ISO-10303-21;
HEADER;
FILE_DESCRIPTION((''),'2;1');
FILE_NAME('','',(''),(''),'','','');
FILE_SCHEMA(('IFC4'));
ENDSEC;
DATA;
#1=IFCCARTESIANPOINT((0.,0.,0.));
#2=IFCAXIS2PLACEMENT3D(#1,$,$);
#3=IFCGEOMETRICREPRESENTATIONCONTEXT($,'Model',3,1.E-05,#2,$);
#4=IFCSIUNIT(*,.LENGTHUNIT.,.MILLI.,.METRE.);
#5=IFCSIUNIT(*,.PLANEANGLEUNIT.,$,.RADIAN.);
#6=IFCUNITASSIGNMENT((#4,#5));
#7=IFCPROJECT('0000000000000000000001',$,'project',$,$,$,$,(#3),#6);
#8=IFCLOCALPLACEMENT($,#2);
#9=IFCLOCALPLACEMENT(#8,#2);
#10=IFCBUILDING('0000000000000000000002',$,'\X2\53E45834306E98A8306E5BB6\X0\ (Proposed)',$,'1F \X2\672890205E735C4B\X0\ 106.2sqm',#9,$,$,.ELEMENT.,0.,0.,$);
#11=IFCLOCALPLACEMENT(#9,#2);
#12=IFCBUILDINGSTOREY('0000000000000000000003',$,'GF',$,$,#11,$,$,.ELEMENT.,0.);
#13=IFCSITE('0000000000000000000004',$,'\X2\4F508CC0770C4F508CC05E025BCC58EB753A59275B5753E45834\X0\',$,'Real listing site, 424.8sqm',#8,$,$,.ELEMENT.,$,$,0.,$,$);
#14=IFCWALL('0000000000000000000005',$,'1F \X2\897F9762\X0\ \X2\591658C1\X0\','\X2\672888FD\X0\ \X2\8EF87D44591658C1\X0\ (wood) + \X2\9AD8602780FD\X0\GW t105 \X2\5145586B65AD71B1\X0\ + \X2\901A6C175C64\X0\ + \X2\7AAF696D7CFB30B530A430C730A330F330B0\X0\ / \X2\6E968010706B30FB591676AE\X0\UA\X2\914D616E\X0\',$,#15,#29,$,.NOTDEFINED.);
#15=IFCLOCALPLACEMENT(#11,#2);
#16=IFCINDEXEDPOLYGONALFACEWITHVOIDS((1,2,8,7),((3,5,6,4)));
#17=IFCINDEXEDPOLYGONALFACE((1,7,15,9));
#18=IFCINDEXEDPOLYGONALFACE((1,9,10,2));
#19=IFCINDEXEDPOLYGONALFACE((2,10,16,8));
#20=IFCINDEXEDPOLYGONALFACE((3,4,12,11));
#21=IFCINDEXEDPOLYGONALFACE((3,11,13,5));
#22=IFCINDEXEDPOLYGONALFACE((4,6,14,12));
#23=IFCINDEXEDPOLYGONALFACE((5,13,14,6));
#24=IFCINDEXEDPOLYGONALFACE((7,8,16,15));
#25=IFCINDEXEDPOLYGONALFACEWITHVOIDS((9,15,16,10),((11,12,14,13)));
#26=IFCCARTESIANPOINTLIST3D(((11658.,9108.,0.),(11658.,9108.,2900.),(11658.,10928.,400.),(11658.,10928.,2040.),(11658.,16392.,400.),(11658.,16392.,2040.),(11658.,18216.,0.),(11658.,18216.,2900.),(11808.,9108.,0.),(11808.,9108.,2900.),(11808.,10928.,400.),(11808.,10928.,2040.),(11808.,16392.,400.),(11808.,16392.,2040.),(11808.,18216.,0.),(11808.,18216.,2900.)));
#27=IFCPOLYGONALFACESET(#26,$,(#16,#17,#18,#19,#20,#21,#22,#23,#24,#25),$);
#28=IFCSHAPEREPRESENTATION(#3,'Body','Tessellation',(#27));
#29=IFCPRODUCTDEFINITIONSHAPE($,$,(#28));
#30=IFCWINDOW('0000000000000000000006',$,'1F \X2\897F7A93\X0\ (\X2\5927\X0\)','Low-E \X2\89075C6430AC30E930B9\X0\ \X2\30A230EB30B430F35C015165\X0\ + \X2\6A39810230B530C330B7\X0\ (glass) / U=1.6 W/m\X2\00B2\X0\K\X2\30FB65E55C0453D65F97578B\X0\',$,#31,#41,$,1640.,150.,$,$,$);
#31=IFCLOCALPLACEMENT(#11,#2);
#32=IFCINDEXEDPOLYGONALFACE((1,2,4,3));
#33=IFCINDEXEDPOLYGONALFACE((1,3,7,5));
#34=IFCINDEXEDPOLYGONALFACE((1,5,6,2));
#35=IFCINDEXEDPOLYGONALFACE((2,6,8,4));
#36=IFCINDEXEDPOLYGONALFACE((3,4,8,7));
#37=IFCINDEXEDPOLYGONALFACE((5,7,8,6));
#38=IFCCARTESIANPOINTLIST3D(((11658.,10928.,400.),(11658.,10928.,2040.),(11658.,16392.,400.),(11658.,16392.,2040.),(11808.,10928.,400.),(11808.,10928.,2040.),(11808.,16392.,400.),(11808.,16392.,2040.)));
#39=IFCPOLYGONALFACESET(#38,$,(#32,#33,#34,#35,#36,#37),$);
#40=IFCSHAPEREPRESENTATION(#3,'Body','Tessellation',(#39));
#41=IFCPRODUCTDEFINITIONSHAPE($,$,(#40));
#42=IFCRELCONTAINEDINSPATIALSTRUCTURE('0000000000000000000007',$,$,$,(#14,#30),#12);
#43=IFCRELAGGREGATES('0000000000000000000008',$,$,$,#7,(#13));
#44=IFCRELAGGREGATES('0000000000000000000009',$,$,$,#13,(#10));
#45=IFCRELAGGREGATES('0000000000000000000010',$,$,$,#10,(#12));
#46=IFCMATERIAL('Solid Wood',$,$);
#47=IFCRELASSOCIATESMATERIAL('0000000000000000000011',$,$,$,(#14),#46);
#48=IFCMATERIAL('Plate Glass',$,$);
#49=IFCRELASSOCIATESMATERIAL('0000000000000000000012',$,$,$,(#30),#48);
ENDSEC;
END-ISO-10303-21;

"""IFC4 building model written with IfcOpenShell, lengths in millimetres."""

from ifc_helpers import new_model, si_unit, frame, frame_2d, origin, place, context, project, spatial, rectangle, extrude, material, element, fill, save


model = new_model("IFC4")

# Units and contexts
model_context = context("Model", 3, precision=1e-05, world=origin())
ifc_project = project(units=[si_unit("LENGTHUNIT", "METRE", prefix="MILLI"), si_unit("PLANEANGLEUNIT", "RADIAN")], contexts=[model_context])

# Site, building, storey
site_placement = place(None, origin())
site = spatial("IfcSite", under=ifc_project, at=site_placement, Name="佐賀県佐賀市富士町大字古場", ObjectType="Real listing site, 424.8sqm", CompositionType="ELEMENT", RefElevation=0.0)
building_placement = place(site_placement, origin())
building = spatial("IfcBuilding", under=site, at=building_placement, Name="古場の風の家 (Proposed)", ObjectType="1F 木造平屋 106.2sqm", CompositionType="ELEMENT", ElevationOfRefHeight=0.0, ElevationOfTerrain=0.0)
storey_placement = place(building_placement, origin())
storey = spatial("IfcBuildingStorey", under=building, at=storey_placement, Name="GF", CompositionType="ELEMENT", Elevation=0.0)

# Shared definitions
ifc_material_1 = material(Name="Solid Wood")

# Shared definitions
ifc_material_2 = material(Name="Plate Glass")

# Wall, opening, window
wall_1_placement = place(storey_placement, frame((5829.0, 4554.0, 0.0)))
wall_1 = element("IfcWall", 1, at=wall_1_placement, inside=storey, material=ifc_material_1, Name="1F 西面 外壁", Description="木製 軸組外壁 (wood) + 高性能GW t105 充填断熱 + 通気層 + 窯業系サイディング / 準耐火・外皮UA配慮", PredefinedType="NOTDEFINED", context=model_context, shape_type="SweptSolid", body=[
    extrude(rectangle(XDim=150.0, YDim=9108.0, at=frame_2d((75.0, 4554.0))), frame((5829.0, 4554.0, 0.0)), (0.0, 0.0, 1.0), 2900.0),
])
opening_1_placement = place(storey_placement, frame((5829.0, 5464.0, 200.0)))
opening_1 = element("IfcOpeningElement", 2, at=opening_1_placement, cuts=wall_1, PredefinedType="NOTDEFINED", context=model_context, shape_type="SweptSolid", body=[
    extrude(rectangle(XDim=150.0, YDim=5464.0, at=frame_2d((75.0, 2732.0))), frame((5829.0, 5464.0, 200.0)), (0.0, 0.0, 1.0), 1640.0),
])
window_1_placement = place(storey_placement, frame((5829.0, 5464.0, 200.0)))
window_1 = element("IfcWindow", 3, at=window_1_placement, inside=storey, material=ifc_material_2, Name="1F 西窓 (大)", Description="Low-E 複層ガラス アルゴン封入 + 樹脂サッシ (glass) / U=1.6 W/m²K・日射取得型", OverallHeight=1640.0, OverallWidth=150.0, context=model_context, shape_type="SweptSolid", body=[
    extrude(rectangle(XDim=150.0, YDim=5464.0, at=frame_2d((75.0, 2732.0))), frame((5829.0, 5464.0, 200.0)), (0.0, 0.0, 1.0), 1640.0),
])
fill(opening_1, window_1)

save(model, "model.ifc")
